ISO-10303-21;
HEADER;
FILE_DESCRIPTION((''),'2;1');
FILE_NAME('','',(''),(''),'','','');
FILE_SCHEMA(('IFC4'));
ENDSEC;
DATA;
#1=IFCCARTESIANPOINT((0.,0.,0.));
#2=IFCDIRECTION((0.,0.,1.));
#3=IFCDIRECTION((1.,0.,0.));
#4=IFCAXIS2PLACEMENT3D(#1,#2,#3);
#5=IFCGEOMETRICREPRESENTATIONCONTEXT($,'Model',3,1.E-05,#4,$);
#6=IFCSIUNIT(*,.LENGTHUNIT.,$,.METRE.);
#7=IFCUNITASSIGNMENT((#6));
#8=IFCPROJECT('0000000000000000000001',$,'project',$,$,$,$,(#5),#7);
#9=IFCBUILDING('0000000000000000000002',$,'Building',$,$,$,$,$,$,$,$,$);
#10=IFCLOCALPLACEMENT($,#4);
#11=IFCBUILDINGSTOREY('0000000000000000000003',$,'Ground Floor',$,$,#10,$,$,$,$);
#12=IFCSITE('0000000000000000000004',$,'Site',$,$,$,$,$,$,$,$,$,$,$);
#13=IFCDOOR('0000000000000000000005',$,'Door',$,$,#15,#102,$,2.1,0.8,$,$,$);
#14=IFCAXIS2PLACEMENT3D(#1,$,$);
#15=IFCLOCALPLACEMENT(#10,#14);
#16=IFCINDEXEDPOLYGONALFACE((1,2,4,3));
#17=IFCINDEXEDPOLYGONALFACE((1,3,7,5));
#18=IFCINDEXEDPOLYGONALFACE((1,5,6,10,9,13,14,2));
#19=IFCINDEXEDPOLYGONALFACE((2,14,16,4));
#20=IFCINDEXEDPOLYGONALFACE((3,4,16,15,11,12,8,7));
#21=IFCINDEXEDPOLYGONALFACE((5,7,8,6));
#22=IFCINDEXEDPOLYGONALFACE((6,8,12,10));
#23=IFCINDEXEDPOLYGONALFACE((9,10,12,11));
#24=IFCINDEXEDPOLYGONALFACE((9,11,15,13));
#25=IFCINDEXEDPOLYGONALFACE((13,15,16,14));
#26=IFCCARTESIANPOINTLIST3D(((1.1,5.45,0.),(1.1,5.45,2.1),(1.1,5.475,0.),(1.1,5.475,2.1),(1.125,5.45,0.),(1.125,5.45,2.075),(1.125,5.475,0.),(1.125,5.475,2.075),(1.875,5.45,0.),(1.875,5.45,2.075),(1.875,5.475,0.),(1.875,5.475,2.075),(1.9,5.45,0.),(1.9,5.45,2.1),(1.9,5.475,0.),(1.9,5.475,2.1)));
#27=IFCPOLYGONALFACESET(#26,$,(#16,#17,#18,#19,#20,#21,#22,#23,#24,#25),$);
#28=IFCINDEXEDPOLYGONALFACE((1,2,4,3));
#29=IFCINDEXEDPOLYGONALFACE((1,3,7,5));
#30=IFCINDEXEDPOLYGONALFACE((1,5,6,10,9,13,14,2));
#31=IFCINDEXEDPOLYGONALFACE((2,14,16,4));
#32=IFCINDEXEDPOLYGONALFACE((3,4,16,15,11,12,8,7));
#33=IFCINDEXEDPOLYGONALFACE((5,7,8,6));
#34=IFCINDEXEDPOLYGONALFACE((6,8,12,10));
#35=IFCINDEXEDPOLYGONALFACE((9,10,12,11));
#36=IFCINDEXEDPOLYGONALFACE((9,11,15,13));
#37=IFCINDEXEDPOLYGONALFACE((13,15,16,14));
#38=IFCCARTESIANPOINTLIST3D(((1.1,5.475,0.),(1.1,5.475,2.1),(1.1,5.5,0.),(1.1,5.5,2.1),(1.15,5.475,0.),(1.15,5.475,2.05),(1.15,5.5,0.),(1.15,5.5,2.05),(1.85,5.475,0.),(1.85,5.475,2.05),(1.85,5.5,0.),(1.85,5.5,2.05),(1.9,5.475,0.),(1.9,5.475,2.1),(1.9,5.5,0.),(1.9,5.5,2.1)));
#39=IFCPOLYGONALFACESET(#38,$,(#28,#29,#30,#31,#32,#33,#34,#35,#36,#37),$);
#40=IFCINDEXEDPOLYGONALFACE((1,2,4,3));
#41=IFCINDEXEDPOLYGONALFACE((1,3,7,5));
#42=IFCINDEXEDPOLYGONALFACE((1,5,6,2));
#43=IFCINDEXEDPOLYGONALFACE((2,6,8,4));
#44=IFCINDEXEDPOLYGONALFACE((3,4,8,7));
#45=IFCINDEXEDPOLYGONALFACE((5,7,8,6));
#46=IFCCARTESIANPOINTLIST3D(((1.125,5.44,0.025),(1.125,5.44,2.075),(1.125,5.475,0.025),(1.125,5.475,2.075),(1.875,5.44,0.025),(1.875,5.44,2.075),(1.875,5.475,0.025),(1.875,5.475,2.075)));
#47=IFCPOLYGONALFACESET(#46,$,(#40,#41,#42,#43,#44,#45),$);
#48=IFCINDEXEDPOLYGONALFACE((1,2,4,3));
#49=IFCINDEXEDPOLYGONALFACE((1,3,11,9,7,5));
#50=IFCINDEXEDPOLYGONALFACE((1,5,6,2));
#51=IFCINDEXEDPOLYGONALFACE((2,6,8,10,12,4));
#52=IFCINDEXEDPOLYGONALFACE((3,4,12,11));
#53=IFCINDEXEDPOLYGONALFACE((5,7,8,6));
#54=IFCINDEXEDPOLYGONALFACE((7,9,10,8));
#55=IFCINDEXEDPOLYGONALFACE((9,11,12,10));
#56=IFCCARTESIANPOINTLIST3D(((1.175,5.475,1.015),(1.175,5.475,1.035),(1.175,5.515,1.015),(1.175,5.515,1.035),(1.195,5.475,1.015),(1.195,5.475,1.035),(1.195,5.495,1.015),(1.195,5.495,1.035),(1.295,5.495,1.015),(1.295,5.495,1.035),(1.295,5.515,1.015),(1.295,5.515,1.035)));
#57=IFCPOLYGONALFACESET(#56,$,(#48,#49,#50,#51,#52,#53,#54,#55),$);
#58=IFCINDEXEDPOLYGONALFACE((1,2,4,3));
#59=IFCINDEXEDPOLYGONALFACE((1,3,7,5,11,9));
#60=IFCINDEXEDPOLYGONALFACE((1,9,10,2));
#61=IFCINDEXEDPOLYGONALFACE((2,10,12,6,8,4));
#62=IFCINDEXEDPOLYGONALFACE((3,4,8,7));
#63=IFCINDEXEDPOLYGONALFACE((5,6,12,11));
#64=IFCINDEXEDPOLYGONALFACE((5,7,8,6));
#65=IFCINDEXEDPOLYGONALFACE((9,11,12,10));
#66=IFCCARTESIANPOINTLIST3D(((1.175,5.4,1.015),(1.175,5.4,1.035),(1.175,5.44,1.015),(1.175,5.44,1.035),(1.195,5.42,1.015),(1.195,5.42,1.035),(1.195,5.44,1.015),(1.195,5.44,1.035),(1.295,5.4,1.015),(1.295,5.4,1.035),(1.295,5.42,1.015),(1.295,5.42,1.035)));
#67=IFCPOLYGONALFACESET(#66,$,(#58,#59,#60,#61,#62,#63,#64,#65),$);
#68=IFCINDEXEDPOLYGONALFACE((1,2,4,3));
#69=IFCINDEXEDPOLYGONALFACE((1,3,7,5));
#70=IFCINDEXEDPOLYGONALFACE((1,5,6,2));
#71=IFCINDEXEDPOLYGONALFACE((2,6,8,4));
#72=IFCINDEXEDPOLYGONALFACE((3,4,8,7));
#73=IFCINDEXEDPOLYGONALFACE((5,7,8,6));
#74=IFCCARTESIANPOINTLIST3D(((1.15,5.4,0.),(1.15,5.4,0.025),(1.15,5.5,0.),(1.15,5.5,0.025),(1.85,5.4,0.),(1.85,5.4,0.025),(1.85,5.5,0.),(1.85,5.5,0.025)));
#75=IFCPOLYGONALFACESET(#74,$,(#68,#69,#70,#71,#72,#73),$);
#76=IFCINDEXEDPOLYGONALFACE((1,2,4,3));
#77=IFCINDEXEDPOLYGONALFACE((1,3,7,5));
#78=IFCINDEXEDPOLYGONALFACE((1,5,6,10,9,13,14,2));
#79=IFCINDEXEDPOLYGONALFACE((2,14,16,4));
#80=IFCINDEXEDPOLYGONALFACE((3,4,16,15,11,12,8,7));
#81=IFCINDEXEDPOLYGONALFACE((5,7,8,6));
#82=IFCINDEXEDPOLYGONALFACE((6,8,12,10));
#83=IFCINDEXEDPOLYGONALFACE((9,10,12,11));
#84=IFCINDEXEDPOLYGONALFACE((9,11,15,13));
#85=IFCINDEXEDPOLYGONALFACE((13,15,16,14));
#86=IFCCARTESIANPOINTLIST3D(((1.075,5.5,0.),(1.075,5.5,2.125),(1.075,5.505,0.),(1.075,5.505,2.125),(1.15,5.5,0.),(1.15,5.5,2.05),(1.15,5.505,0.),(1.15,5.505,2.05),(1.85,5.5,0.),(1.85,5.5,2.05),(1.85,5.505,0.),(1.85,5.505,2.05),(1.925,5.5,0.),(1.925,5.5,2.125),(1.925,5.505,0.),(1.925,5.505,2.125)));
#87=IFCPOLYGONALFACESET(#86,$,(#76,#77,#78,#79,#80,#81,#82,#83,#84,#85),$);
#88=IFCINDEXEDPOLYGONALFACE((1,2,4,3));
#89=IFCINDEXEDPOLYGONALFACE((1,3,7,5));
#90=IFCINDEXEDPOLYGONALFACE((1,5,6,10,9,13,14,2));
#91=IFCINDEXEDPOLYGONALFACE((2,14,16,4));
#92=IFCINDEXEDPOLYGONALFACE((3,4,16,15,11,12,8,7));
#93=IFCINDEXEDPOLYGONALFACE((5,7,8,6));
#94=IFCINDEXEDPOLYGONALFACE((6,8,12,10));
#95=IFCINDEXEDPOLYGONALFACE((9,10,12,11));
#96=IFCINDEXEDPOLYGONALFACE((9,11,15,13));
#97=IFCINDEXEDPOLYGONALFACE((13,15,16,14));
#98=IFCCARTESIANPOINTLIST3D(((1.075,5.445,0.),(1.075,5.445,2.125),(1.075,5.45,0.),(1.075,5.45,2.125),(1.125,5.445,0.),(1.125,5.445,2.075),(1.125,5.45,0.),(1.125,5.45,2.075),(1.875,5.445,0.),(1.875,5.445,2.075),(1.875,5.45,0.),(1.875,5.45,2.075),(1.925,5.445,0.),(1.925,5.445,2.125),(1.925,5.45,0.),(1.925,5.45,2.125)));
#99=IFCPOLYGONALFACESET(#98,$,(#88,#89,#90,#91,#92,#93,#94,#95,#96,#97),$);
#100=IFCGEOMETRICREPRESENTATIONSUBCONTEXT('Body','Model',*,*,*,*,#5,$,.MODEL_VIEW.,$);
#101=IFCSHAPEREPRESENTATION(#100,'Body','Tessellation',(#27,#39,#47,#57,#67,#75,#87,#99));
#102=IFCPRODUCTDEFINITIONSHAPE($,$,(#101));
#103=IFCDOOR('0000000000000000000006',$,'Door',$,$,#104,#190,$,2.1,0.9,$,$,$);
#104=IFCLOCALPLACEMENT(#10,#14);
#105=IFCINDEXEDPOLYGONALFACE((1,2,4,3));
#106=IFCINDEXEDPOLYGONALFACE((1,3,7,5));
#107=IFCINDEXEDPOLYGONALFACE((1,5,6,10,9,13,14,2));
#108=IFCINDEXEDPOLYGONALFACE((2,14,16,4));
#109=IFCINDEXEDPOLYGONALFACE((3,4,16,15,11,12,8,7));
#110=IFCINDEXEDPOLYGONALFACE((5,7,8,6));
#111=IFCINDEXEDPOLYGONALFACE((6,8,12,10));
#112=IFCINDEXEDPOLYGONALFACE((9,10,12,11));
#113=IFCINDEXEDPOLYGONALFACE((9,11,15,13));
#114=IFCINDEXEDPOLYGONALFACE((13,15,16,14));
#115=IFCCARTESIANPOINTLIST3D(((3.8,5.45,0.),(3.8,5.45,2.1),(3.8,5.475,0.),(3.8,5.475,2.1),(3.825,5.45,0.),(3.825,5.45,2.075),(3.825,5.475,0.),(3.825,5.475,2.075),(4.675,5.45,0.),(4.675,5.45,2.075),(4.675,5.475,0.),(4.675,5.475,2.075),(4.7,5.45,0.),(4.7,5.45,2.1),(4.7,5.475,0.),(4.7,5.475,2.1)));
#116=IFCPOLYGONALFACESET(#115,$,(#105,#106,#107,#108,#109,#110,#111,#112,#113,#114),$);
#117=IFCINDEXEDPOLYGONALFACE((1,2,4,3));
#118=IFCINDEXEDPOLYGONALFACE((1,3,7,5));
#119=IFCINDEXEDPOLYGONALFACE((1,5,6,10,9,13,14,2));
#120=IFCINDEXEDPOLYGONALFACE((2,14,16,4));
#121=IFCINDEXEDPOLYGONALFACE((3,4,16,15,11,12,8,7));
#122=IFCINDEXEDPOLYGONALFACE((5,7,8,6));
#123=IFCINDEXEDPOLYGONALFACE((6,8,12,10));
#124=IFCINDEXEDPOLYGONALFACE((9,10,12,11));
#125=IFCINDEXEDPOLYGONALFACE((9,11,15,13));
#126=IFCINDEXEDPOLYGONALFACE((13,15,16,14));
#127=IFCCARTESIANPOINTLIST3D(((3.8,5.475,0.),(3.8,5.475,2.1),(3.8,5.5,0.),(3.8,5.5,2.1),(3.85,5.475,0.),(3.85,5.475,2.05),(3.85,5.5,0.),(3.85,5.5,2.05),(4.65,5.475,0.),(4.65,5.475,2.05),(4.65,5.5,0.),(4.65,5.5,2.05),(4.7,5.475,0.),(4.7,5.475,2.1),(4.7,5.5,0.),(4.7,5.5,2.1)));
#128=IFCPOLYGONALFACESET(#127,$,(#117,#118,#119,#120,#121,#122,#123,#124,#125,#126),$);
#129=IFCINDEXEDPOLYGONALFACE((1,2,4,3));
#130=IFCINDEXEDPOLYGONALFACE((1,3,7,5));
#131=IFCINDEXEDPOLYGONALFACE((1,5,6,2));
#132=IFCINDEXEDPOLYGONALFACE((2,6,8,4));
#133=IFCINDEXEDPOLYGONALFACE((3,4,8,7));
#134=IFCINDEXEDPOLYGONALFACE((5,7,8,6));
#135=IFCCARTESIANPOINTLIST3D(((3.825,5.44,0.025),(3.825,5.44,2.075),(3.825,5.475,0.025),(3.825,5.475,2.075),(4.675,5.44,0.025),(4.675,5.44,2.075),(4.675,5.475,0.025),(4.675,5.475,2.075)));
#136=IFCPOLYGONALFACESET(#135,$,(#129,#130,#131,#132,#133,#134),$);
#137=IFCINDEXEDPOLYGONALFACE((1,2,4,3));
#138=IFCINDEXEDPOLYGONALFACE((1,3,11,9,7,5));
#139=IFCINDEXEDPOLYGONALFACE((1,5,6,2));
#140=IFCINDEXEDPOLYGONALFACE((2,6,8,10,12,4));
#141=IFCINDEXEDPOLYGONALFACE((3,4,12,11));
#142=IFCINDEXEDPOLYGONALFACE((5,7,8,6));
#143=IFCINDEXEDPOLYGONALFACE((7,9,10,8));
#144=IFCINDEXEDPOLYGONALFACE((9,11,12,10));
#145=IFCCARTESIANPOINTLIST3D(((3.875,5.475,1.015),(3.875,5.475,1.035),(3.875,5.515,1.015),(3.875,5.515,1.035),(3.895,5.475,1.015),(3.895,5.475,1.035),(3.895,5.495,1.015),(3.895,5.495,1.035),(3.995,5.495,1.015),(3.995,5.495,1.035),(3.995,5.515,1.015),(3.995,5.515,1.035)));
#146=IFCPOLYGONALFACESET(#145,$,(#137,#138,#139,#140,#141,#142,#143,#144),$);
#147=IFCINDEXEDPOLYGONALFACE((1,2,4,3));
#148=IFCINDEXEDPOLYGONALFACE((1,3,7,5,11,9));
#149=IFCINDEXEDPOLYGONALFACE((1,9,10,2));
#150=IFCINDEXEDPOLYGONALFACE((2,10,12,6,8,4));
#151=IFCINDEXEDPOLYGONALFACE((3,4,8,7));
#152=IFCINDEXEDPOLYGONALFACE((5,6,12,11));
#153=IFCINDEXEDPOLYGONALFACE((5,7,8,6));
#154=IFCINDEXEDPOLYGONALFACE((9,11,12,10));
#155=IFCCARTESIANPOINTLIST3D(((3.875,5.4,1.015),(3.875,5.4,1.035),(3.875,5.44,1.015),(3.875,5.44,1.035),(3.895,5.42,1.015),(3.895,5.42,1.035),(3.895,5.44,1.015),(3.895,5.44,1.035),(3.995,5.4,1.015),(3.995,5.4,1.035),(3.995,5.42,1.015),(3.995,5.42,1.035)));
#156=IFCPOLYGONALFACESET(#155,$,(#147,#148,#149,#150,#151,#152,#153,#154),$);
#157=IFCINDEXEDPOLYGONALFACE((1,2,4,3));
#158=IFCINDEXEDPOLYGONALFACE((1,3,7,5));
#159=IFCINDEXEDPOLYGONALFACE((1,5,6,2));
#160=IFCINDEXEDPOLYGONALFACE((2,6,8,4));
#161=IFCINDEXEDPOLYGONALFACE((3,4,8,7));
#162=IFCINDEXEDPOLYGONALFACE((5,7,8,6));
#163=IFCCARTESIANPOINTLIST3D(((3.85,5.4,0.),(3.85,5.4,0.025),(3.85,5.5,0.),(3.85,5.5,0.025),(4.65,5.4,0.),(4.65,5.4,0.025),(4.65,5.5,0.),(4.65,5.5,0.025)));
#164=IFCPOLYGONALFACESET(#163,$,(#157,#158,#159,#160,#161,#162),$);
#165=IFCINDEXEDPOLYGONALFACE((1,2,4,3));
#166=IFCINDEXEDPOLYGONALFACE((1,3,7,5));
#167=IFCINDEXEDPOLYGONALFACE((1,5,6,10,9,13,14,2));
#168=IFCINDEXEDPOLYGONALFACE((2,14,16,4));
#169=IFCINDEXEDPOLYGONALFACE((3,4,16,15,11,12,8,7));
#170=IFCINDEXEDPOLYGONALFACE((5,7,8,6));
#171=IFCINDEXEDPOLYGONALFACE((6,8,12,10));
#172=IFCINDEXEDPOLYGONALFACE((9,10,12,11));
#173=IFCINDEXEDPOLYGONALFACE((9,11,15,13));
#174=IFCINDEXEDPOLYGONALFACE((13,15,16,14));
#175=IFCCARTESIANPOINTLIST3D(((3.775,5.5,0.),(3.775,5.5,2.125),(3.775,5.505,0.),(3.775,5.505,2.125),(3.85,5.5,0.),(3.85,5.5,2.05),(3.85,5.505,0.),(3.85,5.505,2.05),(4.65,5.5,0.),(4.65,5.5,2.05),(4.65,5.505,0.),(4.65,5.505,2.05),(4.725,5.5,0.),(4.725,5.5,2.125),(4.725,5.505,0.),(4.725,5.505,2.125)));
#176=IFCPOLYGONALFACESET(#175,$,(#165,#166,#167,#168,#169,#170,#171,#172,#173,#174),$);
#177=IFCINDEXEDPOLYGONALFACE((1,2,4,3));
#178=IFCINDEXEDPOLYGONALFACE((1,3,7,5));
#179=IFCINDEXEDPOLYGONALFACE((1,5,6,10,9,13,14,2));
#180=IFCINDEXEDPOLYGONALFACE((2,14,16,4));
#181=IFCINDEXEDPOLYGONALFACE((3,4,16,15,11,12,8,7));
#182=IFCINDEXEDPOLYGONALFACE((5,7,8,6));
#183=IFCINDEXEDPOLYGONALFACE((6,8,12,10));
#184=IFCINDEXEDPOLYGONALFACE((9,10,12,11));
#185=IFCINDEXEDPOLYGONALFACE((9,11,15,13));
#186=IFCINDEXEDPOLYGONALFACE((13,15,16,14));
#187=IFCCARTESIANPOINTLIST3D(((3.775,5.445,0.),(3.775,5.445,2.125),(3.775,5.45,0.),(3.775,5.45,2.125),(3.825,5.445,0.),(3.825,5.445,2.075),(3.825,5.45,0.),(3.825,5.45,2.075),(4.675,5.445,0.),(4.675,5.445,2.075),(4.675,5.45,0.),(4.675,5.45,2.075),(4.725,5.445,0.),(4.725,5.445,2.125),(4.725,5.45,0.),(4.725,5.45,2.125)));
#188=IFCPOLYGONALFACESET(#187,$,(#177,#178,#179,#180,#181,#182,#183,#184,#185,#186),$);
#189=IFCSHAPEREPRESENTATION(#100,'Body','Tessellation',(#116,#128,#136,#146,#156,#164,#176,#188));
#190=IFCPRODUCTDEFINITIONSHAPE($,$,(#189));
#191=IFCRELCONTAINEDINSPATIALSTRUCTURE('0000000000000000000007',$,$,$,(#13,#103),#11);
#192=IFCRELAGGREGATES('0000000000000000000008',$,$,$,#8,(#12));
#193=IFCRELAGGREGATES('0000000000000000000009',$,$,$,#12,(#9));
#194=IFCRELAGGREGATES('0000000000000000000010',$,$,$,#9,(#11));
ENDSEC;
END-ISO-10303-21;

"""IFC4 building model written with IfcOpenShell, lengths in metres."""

from ifc_helpers import new_model, si_unit, frame, origin_with_axes, place, context, subcontext, project, spatial, line, indexed_curve, outline, extrude, element, save


model = new_model("IFC4")

# Units and contexts
model_context = context("Model", 3, precision=1e-05, world=origin_with_axes())
body_context = subcontext(model_context, "Body", "Model", "MODEL_VIEW")
ifc_project = project(units=[si_unit("LENGTHUNIT", "METRE")], contexts=[model_context])

# Site, building, storey
site = spatial("IfcSite", under=ifc_project, Name="Site")
building = spatial("IfcBuilding", under=site, Name="Building")
storey_placement = place(None, origin_with_axes())
storey = spatial("IfcBuildingStorey", under=building, at=storey_placement, Name="Ground Floor")

# Doors
door_1_placement = place(storey_placement, frame((1.9, 5.5, 0.0), z_axis=(0.0, 0.0, 1.0), x_axis=(-1.0, 0.0, 0.0)))
element("IfcDoor", 1, at=door_1_placement, inside=storey, Name="Door", OverallHeight=2.1, OverallWidth=0.8, context=body_context, shape_type="SweptSolid", body=[
    extrude(outline(indexed_curve([(0.0, 0.0), (0.0, 2.1), (0.8, 2.1), (0.8, 0.0), (0.775, 0.0), (0.775, 2.075), (0.025, 2.075), (0.025, 0.0)], segments=[line(1, 2, 3, 4, 5, 6, 7, 8, 1)])), frame((0.0, 0.025, 0.0), z_axis=(0.0, -1.0, 0.0), x_axis=(1.0, 0.0, 0.0)), (0.0, 0.0, -1.0), 0.025),
    extrude(outline(indexed_curve([(0.0, 0.0), (0.0, 2.1), (0.8, 2.1), (0.8, 0.0), (0.75, 0.0), (0.75, 2.05), (0.05, 2.05), (0.05, 0.0)], segments=[line(1, 2, 3, 4, 5, 6, 7, 8, 1)])), frame((0.0, 0.0, 0.0), z_axis=(0.0, -1.0, 0.0), x_axis=(1.0, 0.0, 0.0)), (0.0, 0.0, -1.0), 0.025),
    extrude(outline(indexed_curve([(0.0, 0.0), (0.75, 0.0), (0.75, 0.035), (0.0, 0.035)], segments=[line(1, 2, 3, 4, 1)])), frame((0.025, 0.025, 0.025), z_axis=(0.0, 0.0, 1.0), x_axis=(1.0, 0.0, 0.0)), (0.0, 0.0, 1.0), 2.05),
    extrude(outline(indexed_curve([(0.0, 0.0), (0.0, -0.04), (-0.12, -0.04), (-0.12, -0.02), (-0.02, -0.02), (-0.02, 0.0)], segments=[line(1, 2, 3, 4, 5, 6, 1)])), frame((0.725, 0.025, 1.015), z_axis=(0.0, 0.0, 1.0), x_axis=(1.0, 0.0, 0.0)), (0.0, 0.0, 1.0), 0.02),
    extrude(outline(indexed_curve([(0.0, 0.0), (0.0, 0.04), (-0.12, 0.04), (-0.12, 0.02), (-0.02, 0.02), (-0.02, 0.0)], segments=[line(1, 2, 3, 4, 5, 6, 1)])), frame((0.725, 0.06, 1.015), z_axis=(0.0, 0.0, 1.0), x_axis=(1.0, 0.0, 0.0)), (0.0, 0.0, 1.0), 0.02),
    extrude(outline(indexed_curve([(0.0, 0.0), (0.7, 0.0), (0.7, 0.1), (0.0, 0.1)], segments=[line(1, 2, 3, 4, 1)])), frame((0.05, 0.0, 0.0), z_axis=(0.0, 0.0, 1.0), x_axis=(1.0, 0.0, 0.0)), (0.0, 0.0, 1.0), 0.025),
    extrude(outline(indexed_curve([(0.0, 0.0), (0.0, 2.125), (0.85, 2.125), (0.85, 0.0), (0.775, 0.0), (0.775, 2.05), (0.075, 2.05), (0.075, 0.0)], segments=[line(1, 2, 3, 4, 5, 6, 7, 8, 1)])), frame((-0.025, -0.005, 0.0), z_axis=(0.0, -1.0, 0.0), x_axis=(1.0, 0.0, 0.0)), (0.0, 0.0, -1.0), 0.005),
    extrude(outline(indexed_curve([(0.0, 0.0), (0.0, 2.125), (0.85, 2.125), (0.85, 0.0), (0.8, 0.0), (0.8, 2.075), (0.05, 2.075), (0.05, 0.0)], segments=[line(1, 2, 3, 4, 5, 6, 7, 8, 1)])), frame((-0.025, 0.05, 0.0), z_axis=(0.0, -1.0, 0.0), x_axis=(1.0, 0.0, 0.0)), (0.0, 0.0, -1.0), 0.005),
])
door_2_placement = place(storey_placement, frame((4.7, 5.5, 0.0), z_axis=(0.0, 0.0, 1.0), x_axis=(-1.0, 0.0, 0.0)))
element("IfcDoor", 2, at=door_2_placement, inside=storey, Name="Door", OverallHeight=2.1, OverallWidth=0.9, context=body_context, shape_type="SweptSolid", body=[
    extrude(outline(indexed_curve([(0.0, 0.0), (0.0, 2.1), (0.9, 2.1), (0.9, 0.0), (0.875, 0.0), (0.875, 2.075), (0.025, 2.075), (0.025, 0.0)], segments=[line(1, 2, 3, 4, 5, 6, 7, 8, 1)])), frame((0.0, 0.025, 0.0), z_axis=(0.0, -1.0, 0.0), x_axis=(1.0, 0.0, 0.0)), (0.0, 0.0, -1.0), 0.025),
    extrude(outline(indexed_curve([(0.0, 0.0), (0.0, 2.1), (0.9, 2.1), (0.9, 0.0), (0.85, 0.0), (0.85, 2.05), (0.05, 2.05), (0.05, 0.0)], segments=[line(1, 2, 3, 4, 5, 6, 7, 8, 1)])), frame((0.0, 0.0, 0.0), z_axis=(0.0, -1.0, 0.0), x_axis=(1.0, 0.0, 0.0)), (0.0, 0.0, -1.0), 0.025),
    extrude(outline(indexed_curve([(0.0, 0.0), (0.85, 0.0), (0.85, 0.035), (0.0, 0.035)], segments=[line(1, 2, 3, 4, 1)])), frame((0.025, 0.025, 0.025), z_axis=(0.0, 0.0, 1.0), x_axis=(1.0, 0.0, 0.0)), (0.0, 0.0, 1.0), 2.05),
    extrude(outline(indexed_curve([(0.0, 0.0), (0.0, -0.04), (-0.12, -0.04), (-0.12, -0.02), (-0.02, -0.02), (-0.02, 0.0)], segments=[line(1, 2, 3, 4, 5, 6, 1)])), frame((0.825, 0.025, 1.015), z_axis=(0.0, 0.0, 1.0), x_axis=(1.0, 0.0, 0.0)), (0.0, 0.0, 1.0), 0.02),
    extrude(outline(indexed_curve([(0.0, 0.0), (0.0, 0.04), (-0.12, 0.04), (-0.12, 0.02), (-0.02, 0.02), (-0.02, 0.0)], segments=[line(1, 2, 3, 4, 5, 6, 1)])), frame((0.825, 0.06, 1.015), z_axis=(0.0, 0.0, 1.0), x_axis=(1.0, 0.0, 0.0)), (0.0, 0.0, 1.0), 0.02),
    extrude(outline(indexed_curve([(0.0, 0.0), (0.8, 0.0), (0.8, 0.1), (0.0, 0.1)], segments=[line(1, 2, 3, 4, 1)])), frame((0.05, 0.0, 0.0), z_axis=(0.0, 0.0, 1.0), x_axis=(1.0, 0.0, 0.0)), (0.0, 0.0, 1.0), 0.025),
    extrude(outline(indexed_curve([(0.0, 0.0), (0.0, 2.125), (0.95, 2.125), (0.95, 0.0), (0.875, 0.0), (0.875, 2.05), (0.075, 2.05), (0.075, 0.0)], segments=[line(1, 2, 3, 4, 5, 6, 7, 8, 1)])), frame((-0.025, -0.005, 0.0), z_axis=(0.0, -1.0, 0.0), x_axis=(1.0, 0.0, 0.0)), (0.0, 0.0, -1.0), 0.005),
    extrude(outline(indexed_curve([(0.0, 0.0), (0.0, 2.125), (0.95, 2.125), (0.95, 0.0), (0.9, 0.0), (0.9, 2.075), (0.05, 2.075), (0.05, 0.0)], segments=[line(1, 2, 3, 4, 5, 6, 7, 8, 1)])), frame((-0.025, 0.05, 0.0), z_axis=(0.0, -1.0, 0.0), x_axis=(1.0, 0.0, 0.0)), (0.0, 0.0, -1.0), 0.005),
])

save(model, "model.ifc")
